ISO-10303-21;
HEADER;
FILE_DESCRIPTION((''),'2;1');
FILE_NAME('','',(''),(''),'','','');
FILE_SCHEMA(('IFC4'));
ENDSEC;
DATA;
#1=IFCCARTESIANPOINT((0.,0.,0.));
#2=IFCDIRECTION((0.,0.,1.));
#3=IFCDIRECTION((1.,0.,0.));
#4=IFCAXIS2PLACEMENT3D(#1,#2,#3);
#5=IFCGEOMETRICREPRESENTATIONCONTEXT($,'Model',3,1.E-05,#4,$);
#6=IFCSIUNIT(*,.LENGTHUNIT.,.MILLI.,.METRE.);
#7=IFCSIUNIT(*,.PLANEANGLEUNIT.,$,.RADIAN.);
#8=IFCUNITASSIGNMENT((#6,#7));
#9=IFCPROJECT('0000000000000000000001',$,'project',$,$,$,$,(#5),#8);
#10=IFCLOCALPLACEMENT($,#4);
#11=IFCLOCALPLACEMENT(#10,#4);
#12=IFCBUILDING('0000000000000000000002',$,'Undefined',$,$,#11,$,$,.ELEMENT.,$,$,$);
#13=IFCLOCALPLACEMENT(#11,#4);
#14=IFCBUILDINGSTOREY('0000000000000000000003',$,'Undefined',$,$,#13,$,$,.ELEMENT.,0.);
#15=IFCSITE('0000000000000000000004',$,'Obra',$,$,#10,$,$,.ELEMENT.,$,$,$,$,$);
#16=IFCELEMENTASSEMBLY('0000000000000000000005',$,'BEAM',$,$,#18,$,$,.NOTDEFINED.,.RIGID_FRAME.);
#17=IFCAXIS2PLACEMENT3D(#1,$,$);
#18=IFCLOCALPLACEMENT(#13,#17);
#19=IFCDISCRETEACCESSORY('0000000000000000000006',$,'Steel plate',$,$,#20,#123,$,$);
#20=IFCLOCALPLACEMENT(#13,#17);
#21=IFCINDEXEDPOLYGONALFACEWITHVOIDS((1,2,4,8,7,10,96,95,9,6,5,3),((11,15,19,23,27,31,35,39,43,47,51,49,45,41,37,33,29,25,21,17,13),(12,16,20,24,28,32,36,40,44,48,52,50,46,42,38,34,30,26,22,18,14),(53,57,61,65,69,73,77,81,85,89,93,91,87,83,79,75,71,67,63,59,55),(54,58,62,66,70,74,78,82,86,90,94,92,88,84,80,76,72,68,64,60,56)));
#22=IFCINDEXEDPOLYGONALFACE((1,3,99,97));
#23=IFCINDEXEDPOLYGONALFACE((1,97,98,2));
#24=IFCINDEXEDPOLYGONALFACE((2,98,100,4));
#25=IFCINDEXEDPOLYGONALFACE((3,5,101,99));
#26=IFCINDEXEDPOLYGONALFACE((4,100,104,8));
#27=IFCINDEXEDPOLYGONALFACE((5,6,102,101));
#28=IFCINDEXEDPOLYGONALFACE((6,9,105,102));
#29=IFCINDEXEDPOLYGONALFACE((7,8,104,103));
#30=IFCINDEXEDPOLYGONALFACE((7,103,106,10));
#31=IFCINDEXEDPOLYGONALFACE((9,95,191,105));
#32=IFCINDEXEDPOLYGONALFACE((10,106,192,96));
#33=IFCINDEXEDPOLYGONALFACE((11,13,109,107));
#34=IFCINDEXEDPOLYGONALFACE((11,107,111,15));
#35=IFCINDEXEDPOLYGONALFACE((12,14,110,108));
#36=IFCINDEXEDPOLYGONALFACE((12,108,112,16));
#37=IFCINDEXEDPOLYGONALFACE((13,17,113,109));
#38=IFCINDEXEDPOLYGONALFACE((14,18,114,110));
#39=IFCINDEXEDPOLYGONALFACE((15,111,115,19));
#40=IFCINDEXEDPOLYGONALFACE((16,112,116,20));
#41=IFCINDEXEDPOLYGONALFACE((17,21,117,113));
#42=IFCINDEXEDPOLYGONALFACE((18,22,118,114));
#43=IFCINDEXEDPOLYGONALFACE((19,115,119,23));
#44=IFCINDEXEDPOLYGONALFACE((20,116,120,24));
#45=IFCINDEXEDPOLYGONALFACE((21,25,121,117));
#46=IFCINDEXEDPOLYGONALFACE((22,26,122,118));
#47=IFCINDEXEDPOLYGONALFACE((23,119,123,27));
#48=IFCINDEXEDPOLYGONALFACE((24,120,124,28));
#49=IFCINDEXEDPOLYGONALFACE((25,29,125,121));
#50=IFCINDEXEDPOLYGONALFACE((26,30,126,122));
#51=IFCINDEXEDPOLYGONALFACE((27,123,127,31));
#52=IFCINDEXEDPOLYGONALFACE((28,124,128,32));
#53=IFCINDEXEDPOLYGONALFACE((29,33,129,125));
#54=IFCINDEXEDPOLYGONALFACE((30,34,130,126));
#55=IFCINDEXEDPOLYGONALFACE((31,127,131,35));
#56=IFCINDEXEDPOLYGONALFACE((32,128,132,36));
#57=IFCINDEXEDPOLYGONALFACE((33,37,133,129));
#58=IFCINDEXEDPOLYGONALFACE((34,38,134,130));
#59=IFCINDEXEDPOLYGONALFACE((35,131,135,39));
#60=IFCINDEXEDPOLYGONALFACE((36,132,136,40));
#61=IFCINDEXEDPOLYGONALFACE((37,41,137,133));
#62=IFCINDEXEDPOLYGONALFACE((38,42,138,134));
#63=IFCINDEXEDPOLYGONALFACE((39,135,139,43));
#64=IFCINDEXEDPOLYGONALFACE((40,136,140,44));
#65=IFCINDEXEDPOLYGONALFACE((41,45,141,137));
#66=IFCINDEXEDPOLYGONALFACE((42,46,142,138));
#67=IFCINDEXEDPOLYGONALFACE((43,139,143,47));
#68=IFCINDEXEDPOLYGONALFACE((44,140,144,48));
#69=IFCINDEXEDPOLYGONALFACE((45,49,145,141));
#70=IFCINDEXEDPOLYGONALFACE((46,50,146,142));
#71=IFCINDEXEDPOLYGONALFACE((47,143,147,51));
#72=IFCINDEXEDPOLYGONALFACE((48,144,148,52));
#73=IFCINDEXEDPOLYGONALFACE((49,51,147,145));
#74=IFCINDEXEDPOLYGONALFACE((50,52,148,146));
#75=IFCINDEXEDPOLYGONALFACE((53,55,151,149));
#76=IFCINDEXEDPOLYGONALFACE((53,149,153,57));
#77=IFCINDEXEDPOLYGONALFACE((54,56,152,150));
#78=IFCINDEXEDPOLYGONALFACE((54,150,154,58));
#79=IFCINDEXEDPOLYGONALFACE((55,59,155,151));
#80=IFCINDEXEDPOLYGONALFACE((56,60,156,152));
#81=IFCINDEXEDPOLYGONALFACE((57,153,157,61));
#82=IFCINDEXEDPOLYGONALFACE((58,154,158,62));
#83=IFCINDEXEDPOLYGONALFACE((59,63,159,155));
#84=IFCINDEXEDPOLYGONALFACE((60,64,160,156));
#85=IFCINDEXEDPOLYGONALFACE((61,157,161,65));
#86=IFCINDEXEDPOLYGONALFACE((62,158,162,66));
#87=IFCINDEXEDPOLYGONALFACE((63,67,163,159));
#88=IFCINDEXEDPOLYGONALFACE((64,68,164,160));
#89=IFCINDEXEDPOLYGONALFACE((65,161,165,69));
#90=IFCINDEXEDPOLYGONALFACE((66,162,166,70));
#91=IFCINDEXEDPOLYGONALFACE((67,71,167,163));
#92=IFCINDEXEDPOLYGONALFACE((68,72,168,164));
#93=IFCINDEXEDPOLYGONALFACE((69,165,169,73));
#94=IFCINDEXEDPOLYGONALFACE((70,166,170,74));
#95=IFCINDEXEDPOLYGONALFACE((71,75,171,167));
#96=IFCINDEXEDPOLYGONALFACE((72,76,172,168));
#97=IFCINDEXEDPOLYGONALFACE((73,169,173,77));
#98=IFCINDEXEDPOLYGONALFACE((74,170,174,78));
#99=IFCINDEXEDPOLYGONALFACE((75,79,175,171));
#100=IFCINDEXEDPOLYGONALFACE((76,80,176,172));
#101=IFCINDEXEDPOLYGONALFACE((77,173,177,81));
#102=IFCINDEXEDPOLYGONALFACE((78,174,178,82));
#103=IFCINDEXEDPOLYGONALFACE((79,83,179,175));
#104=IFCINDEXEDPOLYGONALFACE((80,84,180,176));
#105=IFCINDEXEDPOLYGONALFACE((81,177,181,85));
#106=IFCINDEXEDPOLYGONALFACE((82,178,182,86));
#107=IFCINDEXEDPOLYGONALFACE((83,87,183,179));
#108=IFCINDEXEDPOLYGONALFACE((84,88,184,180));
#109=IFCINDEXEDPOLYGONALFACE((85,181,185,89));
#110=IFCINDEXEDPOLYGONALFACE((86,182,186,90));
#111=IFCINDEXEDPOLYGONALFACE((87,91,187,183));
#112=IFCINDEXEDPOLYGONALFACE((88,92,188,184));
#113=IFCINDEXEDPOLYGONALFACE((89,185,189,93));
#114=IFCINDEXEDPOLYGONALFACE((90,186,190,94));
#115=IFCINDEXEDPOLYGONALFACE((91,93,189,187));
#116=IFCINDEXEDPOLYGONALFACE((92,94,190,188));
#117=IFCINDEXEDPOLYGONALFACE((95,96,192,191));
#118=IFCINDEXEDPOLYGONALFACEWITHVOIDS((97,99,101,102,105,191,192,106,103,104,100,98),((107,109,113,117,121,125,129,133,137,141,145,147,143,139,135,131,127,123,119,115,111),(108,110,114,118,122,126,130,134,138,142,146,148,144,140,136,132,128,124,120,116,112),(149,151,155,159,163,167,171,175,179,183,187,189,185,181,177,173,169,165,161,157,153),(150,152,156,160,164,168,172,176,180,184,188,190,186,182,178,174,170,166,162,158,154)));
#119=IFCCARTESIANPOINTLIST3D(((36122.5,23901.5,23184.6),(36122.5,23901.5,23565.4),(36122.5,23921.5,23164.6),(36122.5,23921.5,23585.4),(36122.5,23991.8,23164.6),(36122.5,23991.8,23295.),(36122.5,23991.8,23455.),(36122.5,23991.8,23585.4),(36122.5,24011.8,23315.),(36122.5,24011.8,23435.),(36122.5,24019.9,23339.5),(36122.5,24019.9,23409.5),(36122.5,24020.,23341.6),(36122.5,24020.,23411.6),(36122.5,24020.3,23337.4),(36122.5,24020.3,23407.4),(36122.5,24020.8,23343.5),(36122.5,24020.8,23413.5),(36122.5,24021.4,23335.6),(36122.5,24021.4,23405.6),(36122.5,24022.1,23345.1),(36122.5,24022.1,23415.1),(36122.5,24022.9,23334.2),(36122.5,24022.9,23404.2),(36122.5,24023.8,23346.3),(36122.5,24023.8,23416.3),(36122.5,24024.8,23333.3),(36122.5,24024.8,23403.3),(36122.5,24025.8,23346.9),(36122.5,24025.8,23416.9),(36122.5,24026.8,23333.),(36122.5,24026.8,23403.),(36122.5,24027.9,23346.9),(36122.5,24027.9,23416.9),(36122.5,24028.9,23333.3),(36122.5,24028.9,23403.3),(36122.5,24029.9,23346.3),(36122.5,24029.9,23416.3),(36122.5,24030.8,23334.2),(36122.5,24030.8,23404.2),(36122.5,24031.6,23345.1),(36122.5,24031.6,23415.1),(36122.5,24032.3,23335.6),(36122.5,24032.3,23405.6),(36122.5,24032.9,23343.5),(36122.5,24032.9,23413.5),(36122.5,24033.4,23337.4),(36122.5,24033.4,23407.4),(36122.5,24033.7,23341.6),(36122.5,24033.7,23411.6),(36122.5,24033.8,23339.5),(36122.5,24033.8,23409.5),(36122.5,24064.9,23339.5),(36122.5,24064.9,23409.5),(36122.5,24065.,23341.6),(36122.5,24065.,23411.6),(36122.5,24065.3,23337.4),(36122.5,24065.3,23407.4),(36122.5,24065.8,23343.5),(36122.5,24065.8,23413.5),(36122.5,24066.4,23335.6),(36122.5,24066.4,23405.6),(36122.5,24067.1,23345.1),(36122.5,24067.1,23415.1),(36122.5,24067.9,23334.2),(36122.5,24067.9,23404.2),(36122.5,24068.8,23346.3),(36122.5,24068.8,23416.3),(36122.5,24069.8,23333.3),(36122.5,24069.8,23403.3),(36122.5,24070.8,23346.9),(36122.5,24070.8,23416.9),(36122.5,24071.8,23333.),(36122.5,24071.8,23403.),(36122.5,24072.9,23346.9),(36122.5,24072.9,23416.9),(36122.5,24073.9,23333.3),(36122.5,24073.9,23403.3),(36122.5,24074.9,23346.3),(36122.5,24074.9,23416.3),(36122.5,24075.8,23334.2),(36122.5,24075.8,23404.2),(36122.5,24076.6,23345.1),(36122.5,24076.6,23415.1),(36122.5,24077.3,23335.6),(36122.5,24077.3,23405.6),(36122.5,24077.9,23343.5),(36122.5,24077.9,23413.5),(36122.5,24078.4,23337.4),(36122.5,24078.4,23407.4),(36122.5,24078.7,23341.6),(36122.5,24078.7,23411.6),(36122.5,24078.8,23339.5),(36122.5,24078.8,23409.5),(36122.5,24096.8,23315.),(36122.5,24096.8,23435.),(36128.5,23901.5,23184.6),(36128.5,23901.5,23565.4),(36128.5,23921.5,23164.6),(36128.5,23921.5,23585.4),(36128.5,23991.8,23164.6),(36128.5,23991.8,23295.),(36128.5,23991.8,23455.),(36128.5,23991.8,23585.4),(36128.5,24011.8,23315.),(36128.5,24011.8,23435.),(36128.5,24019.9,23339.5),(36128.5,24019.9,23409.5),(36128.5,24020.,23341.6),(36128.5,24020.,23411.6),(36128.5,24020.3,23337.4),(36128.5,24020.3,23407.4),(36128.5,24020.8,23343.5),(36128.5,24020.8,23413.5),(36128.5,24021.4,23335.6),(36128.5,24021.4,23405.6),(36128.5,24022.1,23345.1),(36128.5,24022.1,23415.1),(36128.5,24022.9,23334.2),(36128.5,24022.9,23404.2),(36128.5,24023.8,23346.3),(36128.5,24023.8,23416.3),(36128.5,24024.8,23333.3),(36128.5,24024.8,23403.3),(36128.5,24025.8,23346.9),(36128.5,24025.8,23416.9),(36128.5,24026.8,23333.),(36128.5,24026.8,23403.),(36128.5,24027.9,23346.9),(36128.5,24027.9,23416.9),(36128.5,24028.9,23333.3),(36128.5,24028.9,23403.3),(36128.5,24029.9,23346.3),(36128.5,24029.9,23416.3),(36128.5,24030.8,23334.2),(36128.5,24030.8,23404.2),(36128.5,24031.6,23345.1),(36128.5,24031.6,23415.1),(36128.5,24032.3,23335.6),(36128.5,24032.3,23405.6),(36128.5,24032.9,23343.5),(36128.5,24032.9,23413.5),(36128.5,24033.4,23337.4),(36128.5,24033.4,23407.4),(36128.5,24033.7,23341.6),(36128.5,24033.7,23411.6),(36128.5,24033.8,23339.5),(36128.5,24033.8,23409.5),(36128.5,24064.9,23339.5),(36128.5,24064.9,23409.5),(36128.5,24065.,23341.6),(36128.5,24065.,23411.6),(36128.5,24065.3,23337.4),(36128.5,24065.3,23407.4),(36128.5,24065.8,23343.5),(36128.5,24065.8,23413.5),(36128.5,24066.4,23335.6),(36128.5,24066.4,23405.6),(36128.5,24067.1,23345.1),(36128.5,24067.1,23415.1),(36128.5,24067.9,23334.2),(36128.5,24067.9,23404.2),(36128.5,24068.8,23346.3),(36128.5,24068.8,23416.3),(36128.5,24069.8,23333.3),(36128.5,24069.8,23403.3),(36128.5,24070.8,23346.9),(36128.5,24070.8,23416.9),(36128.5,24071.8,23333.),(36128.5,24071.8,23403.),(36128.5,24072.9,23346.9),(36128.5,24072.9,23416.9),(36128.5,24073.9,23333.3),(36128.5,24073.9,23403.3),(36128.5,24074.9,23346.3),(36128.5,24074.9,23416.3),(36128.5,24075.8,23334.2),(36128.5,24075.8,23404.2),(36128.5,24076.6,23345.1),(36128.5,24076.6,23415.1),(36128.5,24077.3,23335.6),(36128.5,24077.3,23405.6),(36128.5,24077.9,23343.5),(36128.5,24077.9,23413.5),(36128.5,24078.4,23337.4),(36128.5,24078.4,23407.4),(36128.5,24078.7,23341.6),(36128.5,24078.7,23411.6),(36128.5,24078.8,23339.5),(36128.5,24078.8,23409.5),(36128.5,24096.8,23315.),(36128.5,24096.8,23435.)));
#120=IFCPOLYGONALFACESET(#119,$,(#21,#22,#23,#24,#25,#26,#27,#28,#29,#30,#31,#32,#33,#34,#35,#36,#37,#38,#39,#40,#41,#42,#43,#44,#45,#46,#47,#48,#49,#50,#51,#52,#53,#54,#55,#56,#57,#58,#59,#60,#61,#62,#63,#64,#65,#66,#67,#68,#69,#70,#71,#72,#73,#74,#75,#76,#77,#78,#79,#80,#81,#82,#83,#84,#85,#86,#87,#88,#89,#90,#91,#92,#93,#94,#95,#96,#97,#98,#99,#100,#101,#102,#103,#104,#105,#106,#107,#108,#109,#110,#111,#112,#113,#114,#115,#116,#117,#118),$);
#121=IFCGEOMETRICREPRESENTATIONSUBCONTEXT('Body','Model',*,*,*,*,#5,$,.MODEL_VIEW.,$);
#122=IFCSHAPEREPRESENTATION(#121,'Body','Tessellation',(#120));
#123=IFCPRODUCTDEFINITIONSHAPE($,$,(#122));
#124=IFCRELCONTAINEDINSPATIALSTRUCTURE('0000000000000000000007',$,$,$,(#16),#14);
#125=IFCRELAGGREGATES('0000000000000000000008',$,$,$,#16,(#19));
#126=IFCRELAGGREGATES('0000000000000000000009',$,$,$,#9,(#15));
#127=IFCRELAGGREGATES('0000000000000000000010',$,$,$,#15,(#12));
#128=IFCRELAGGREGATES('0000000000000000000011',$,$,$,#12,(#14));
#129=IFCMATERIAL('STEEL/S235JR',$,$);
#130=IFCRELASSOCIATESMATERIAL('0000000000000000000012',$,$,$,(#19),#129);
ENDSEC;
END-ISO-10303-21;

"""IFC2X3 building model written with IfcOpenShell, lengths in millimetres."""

from ifc_helpers import new_model, si_unit, frame, origin_with_axes, origin_2d_with_axis, place, context, subcontext, project, spatial, polyline, circle, outline, extrude, source, transform, mapped, material, element, aggregate, save


model = new_model("IFC2X3")

# Units and contexts
model_context = context("Model", 3, precision=1e-05, world=origin_with_axes())
body_context = subcontext(model_context, "Body", "Model", "MODEL_VIEW")
ifc_project = project(units=[si_unit("LENGTHUNIT", "METRE", prefix="MILLI"), si_unit("PLANEANGLEUNIT", "RADIAN")], contexts=[model_context])

# Site, building, storey
site_placement = place(None, origin_with_axes())
site = spatial("IfcSite", under=ifc_project, at=site_placement, Name="Obra", CompositionType="ELEMENT")
building_placement = place(site_placement, origin_with_axes())
building = spatial("IfcBuilding", under=site, at=building_placement, Name="Undefined", CompositionType="ELEMENT")
storey_placement = place(building_placement, origin_with_axes())
storey = spatial("IfcBuildingStorey", under=building, at=storey_placement, Name="Undefined", CompositionType="ELEMENT", Elevation=0.0)

# Shared definitions
ifc_material_1 = material(Name="STEEL/S235JR")

# Shared definitions
shared_shape_1 = source(origin_with_axes(), body_context, "Body", "SweptSolid", [
    extrude(circle(Radius=7.0, at=origin_2d_with_axis()), frame((0.0, -8.6, 0.0), z_axis=(0.0, 1.0, 0.0), x_axis=(1.0, 0.0, 0.0)), (0.0, 0.0, 1.0), 6.2),
])

# Element assembly, discrete accessory, opening
assembly_1_placement = place(storey_placement, origin_with_axes())
assembly_1 = element("IfcElementAssembly", 1, at=assembly_1_placement, inside=storey, Name="BEAM", AssemblyPlace="NOTDEFINED", PredefinedType="RIGID_FRAME")
discrete_accessory_1_placement = place(assembly_1_placement, frame((36125.5, 23901.5, 23184.6), z_axis=(1.0, 0.0, 0.0), x_axis=(-0.000001, 0.707107, -0.707107)))
discrete_accessory_1 = element("IfcDiscreteAccessory", 2, at=discrete_accessory_1_placement, material=ifc_material_1, Name="Steel plate", context=body_context, shape_type="SweptSolid", body=[
    extrude(outline(polyline([(0.0, 0.0), (28.3, 0.0), (78.0, 49.7), (-14.2, 141.9), (-14.2, 170.2), (45.9, 230.3), (-39.0, 315.2), (-99.1, 255.1), (-127.3, 255.1), (-219.6, 347.3), (-269.3, 297.6), (-269.3, 269.3), (0.0, 0.0)])), frame((0.0, 0.0, -3.0), z_axis=(0.0, 0.0, 1.0), x_axis=(1.0, 0.0, 0.0)), (0.0, 0.0, 1.0), 6.0),
])
opening_1_placement = place(assembly_1_placement, frame((36120.0, 24001.8, 23435.0), z_axis=(0.0, 1.0, 0.0), x_axis=(0.0, 0.0, -1.0)))
element("IfcOpeningElement", 3, at=opening_1_placement, cuts=discrete_accessory_1, ObjectType="Opening", context=body_context, shape_type="MappedRepresentation", body=[
    mapped(shared_shape_1, transform((25.0, 0.0, 25.0))),
    mapped(shared_shape_1, transform((25.0, 0.0, 70.0))),
    mapped(shared_shape_1, transform((95.0, 0.0, 25.0))),
    mapped(shared_shape_1, transform((95.0, 0.0, 70.0))),
])
aggregate(assembly_1, [discrete_accessory_1])

save(model, "model.ifc")
